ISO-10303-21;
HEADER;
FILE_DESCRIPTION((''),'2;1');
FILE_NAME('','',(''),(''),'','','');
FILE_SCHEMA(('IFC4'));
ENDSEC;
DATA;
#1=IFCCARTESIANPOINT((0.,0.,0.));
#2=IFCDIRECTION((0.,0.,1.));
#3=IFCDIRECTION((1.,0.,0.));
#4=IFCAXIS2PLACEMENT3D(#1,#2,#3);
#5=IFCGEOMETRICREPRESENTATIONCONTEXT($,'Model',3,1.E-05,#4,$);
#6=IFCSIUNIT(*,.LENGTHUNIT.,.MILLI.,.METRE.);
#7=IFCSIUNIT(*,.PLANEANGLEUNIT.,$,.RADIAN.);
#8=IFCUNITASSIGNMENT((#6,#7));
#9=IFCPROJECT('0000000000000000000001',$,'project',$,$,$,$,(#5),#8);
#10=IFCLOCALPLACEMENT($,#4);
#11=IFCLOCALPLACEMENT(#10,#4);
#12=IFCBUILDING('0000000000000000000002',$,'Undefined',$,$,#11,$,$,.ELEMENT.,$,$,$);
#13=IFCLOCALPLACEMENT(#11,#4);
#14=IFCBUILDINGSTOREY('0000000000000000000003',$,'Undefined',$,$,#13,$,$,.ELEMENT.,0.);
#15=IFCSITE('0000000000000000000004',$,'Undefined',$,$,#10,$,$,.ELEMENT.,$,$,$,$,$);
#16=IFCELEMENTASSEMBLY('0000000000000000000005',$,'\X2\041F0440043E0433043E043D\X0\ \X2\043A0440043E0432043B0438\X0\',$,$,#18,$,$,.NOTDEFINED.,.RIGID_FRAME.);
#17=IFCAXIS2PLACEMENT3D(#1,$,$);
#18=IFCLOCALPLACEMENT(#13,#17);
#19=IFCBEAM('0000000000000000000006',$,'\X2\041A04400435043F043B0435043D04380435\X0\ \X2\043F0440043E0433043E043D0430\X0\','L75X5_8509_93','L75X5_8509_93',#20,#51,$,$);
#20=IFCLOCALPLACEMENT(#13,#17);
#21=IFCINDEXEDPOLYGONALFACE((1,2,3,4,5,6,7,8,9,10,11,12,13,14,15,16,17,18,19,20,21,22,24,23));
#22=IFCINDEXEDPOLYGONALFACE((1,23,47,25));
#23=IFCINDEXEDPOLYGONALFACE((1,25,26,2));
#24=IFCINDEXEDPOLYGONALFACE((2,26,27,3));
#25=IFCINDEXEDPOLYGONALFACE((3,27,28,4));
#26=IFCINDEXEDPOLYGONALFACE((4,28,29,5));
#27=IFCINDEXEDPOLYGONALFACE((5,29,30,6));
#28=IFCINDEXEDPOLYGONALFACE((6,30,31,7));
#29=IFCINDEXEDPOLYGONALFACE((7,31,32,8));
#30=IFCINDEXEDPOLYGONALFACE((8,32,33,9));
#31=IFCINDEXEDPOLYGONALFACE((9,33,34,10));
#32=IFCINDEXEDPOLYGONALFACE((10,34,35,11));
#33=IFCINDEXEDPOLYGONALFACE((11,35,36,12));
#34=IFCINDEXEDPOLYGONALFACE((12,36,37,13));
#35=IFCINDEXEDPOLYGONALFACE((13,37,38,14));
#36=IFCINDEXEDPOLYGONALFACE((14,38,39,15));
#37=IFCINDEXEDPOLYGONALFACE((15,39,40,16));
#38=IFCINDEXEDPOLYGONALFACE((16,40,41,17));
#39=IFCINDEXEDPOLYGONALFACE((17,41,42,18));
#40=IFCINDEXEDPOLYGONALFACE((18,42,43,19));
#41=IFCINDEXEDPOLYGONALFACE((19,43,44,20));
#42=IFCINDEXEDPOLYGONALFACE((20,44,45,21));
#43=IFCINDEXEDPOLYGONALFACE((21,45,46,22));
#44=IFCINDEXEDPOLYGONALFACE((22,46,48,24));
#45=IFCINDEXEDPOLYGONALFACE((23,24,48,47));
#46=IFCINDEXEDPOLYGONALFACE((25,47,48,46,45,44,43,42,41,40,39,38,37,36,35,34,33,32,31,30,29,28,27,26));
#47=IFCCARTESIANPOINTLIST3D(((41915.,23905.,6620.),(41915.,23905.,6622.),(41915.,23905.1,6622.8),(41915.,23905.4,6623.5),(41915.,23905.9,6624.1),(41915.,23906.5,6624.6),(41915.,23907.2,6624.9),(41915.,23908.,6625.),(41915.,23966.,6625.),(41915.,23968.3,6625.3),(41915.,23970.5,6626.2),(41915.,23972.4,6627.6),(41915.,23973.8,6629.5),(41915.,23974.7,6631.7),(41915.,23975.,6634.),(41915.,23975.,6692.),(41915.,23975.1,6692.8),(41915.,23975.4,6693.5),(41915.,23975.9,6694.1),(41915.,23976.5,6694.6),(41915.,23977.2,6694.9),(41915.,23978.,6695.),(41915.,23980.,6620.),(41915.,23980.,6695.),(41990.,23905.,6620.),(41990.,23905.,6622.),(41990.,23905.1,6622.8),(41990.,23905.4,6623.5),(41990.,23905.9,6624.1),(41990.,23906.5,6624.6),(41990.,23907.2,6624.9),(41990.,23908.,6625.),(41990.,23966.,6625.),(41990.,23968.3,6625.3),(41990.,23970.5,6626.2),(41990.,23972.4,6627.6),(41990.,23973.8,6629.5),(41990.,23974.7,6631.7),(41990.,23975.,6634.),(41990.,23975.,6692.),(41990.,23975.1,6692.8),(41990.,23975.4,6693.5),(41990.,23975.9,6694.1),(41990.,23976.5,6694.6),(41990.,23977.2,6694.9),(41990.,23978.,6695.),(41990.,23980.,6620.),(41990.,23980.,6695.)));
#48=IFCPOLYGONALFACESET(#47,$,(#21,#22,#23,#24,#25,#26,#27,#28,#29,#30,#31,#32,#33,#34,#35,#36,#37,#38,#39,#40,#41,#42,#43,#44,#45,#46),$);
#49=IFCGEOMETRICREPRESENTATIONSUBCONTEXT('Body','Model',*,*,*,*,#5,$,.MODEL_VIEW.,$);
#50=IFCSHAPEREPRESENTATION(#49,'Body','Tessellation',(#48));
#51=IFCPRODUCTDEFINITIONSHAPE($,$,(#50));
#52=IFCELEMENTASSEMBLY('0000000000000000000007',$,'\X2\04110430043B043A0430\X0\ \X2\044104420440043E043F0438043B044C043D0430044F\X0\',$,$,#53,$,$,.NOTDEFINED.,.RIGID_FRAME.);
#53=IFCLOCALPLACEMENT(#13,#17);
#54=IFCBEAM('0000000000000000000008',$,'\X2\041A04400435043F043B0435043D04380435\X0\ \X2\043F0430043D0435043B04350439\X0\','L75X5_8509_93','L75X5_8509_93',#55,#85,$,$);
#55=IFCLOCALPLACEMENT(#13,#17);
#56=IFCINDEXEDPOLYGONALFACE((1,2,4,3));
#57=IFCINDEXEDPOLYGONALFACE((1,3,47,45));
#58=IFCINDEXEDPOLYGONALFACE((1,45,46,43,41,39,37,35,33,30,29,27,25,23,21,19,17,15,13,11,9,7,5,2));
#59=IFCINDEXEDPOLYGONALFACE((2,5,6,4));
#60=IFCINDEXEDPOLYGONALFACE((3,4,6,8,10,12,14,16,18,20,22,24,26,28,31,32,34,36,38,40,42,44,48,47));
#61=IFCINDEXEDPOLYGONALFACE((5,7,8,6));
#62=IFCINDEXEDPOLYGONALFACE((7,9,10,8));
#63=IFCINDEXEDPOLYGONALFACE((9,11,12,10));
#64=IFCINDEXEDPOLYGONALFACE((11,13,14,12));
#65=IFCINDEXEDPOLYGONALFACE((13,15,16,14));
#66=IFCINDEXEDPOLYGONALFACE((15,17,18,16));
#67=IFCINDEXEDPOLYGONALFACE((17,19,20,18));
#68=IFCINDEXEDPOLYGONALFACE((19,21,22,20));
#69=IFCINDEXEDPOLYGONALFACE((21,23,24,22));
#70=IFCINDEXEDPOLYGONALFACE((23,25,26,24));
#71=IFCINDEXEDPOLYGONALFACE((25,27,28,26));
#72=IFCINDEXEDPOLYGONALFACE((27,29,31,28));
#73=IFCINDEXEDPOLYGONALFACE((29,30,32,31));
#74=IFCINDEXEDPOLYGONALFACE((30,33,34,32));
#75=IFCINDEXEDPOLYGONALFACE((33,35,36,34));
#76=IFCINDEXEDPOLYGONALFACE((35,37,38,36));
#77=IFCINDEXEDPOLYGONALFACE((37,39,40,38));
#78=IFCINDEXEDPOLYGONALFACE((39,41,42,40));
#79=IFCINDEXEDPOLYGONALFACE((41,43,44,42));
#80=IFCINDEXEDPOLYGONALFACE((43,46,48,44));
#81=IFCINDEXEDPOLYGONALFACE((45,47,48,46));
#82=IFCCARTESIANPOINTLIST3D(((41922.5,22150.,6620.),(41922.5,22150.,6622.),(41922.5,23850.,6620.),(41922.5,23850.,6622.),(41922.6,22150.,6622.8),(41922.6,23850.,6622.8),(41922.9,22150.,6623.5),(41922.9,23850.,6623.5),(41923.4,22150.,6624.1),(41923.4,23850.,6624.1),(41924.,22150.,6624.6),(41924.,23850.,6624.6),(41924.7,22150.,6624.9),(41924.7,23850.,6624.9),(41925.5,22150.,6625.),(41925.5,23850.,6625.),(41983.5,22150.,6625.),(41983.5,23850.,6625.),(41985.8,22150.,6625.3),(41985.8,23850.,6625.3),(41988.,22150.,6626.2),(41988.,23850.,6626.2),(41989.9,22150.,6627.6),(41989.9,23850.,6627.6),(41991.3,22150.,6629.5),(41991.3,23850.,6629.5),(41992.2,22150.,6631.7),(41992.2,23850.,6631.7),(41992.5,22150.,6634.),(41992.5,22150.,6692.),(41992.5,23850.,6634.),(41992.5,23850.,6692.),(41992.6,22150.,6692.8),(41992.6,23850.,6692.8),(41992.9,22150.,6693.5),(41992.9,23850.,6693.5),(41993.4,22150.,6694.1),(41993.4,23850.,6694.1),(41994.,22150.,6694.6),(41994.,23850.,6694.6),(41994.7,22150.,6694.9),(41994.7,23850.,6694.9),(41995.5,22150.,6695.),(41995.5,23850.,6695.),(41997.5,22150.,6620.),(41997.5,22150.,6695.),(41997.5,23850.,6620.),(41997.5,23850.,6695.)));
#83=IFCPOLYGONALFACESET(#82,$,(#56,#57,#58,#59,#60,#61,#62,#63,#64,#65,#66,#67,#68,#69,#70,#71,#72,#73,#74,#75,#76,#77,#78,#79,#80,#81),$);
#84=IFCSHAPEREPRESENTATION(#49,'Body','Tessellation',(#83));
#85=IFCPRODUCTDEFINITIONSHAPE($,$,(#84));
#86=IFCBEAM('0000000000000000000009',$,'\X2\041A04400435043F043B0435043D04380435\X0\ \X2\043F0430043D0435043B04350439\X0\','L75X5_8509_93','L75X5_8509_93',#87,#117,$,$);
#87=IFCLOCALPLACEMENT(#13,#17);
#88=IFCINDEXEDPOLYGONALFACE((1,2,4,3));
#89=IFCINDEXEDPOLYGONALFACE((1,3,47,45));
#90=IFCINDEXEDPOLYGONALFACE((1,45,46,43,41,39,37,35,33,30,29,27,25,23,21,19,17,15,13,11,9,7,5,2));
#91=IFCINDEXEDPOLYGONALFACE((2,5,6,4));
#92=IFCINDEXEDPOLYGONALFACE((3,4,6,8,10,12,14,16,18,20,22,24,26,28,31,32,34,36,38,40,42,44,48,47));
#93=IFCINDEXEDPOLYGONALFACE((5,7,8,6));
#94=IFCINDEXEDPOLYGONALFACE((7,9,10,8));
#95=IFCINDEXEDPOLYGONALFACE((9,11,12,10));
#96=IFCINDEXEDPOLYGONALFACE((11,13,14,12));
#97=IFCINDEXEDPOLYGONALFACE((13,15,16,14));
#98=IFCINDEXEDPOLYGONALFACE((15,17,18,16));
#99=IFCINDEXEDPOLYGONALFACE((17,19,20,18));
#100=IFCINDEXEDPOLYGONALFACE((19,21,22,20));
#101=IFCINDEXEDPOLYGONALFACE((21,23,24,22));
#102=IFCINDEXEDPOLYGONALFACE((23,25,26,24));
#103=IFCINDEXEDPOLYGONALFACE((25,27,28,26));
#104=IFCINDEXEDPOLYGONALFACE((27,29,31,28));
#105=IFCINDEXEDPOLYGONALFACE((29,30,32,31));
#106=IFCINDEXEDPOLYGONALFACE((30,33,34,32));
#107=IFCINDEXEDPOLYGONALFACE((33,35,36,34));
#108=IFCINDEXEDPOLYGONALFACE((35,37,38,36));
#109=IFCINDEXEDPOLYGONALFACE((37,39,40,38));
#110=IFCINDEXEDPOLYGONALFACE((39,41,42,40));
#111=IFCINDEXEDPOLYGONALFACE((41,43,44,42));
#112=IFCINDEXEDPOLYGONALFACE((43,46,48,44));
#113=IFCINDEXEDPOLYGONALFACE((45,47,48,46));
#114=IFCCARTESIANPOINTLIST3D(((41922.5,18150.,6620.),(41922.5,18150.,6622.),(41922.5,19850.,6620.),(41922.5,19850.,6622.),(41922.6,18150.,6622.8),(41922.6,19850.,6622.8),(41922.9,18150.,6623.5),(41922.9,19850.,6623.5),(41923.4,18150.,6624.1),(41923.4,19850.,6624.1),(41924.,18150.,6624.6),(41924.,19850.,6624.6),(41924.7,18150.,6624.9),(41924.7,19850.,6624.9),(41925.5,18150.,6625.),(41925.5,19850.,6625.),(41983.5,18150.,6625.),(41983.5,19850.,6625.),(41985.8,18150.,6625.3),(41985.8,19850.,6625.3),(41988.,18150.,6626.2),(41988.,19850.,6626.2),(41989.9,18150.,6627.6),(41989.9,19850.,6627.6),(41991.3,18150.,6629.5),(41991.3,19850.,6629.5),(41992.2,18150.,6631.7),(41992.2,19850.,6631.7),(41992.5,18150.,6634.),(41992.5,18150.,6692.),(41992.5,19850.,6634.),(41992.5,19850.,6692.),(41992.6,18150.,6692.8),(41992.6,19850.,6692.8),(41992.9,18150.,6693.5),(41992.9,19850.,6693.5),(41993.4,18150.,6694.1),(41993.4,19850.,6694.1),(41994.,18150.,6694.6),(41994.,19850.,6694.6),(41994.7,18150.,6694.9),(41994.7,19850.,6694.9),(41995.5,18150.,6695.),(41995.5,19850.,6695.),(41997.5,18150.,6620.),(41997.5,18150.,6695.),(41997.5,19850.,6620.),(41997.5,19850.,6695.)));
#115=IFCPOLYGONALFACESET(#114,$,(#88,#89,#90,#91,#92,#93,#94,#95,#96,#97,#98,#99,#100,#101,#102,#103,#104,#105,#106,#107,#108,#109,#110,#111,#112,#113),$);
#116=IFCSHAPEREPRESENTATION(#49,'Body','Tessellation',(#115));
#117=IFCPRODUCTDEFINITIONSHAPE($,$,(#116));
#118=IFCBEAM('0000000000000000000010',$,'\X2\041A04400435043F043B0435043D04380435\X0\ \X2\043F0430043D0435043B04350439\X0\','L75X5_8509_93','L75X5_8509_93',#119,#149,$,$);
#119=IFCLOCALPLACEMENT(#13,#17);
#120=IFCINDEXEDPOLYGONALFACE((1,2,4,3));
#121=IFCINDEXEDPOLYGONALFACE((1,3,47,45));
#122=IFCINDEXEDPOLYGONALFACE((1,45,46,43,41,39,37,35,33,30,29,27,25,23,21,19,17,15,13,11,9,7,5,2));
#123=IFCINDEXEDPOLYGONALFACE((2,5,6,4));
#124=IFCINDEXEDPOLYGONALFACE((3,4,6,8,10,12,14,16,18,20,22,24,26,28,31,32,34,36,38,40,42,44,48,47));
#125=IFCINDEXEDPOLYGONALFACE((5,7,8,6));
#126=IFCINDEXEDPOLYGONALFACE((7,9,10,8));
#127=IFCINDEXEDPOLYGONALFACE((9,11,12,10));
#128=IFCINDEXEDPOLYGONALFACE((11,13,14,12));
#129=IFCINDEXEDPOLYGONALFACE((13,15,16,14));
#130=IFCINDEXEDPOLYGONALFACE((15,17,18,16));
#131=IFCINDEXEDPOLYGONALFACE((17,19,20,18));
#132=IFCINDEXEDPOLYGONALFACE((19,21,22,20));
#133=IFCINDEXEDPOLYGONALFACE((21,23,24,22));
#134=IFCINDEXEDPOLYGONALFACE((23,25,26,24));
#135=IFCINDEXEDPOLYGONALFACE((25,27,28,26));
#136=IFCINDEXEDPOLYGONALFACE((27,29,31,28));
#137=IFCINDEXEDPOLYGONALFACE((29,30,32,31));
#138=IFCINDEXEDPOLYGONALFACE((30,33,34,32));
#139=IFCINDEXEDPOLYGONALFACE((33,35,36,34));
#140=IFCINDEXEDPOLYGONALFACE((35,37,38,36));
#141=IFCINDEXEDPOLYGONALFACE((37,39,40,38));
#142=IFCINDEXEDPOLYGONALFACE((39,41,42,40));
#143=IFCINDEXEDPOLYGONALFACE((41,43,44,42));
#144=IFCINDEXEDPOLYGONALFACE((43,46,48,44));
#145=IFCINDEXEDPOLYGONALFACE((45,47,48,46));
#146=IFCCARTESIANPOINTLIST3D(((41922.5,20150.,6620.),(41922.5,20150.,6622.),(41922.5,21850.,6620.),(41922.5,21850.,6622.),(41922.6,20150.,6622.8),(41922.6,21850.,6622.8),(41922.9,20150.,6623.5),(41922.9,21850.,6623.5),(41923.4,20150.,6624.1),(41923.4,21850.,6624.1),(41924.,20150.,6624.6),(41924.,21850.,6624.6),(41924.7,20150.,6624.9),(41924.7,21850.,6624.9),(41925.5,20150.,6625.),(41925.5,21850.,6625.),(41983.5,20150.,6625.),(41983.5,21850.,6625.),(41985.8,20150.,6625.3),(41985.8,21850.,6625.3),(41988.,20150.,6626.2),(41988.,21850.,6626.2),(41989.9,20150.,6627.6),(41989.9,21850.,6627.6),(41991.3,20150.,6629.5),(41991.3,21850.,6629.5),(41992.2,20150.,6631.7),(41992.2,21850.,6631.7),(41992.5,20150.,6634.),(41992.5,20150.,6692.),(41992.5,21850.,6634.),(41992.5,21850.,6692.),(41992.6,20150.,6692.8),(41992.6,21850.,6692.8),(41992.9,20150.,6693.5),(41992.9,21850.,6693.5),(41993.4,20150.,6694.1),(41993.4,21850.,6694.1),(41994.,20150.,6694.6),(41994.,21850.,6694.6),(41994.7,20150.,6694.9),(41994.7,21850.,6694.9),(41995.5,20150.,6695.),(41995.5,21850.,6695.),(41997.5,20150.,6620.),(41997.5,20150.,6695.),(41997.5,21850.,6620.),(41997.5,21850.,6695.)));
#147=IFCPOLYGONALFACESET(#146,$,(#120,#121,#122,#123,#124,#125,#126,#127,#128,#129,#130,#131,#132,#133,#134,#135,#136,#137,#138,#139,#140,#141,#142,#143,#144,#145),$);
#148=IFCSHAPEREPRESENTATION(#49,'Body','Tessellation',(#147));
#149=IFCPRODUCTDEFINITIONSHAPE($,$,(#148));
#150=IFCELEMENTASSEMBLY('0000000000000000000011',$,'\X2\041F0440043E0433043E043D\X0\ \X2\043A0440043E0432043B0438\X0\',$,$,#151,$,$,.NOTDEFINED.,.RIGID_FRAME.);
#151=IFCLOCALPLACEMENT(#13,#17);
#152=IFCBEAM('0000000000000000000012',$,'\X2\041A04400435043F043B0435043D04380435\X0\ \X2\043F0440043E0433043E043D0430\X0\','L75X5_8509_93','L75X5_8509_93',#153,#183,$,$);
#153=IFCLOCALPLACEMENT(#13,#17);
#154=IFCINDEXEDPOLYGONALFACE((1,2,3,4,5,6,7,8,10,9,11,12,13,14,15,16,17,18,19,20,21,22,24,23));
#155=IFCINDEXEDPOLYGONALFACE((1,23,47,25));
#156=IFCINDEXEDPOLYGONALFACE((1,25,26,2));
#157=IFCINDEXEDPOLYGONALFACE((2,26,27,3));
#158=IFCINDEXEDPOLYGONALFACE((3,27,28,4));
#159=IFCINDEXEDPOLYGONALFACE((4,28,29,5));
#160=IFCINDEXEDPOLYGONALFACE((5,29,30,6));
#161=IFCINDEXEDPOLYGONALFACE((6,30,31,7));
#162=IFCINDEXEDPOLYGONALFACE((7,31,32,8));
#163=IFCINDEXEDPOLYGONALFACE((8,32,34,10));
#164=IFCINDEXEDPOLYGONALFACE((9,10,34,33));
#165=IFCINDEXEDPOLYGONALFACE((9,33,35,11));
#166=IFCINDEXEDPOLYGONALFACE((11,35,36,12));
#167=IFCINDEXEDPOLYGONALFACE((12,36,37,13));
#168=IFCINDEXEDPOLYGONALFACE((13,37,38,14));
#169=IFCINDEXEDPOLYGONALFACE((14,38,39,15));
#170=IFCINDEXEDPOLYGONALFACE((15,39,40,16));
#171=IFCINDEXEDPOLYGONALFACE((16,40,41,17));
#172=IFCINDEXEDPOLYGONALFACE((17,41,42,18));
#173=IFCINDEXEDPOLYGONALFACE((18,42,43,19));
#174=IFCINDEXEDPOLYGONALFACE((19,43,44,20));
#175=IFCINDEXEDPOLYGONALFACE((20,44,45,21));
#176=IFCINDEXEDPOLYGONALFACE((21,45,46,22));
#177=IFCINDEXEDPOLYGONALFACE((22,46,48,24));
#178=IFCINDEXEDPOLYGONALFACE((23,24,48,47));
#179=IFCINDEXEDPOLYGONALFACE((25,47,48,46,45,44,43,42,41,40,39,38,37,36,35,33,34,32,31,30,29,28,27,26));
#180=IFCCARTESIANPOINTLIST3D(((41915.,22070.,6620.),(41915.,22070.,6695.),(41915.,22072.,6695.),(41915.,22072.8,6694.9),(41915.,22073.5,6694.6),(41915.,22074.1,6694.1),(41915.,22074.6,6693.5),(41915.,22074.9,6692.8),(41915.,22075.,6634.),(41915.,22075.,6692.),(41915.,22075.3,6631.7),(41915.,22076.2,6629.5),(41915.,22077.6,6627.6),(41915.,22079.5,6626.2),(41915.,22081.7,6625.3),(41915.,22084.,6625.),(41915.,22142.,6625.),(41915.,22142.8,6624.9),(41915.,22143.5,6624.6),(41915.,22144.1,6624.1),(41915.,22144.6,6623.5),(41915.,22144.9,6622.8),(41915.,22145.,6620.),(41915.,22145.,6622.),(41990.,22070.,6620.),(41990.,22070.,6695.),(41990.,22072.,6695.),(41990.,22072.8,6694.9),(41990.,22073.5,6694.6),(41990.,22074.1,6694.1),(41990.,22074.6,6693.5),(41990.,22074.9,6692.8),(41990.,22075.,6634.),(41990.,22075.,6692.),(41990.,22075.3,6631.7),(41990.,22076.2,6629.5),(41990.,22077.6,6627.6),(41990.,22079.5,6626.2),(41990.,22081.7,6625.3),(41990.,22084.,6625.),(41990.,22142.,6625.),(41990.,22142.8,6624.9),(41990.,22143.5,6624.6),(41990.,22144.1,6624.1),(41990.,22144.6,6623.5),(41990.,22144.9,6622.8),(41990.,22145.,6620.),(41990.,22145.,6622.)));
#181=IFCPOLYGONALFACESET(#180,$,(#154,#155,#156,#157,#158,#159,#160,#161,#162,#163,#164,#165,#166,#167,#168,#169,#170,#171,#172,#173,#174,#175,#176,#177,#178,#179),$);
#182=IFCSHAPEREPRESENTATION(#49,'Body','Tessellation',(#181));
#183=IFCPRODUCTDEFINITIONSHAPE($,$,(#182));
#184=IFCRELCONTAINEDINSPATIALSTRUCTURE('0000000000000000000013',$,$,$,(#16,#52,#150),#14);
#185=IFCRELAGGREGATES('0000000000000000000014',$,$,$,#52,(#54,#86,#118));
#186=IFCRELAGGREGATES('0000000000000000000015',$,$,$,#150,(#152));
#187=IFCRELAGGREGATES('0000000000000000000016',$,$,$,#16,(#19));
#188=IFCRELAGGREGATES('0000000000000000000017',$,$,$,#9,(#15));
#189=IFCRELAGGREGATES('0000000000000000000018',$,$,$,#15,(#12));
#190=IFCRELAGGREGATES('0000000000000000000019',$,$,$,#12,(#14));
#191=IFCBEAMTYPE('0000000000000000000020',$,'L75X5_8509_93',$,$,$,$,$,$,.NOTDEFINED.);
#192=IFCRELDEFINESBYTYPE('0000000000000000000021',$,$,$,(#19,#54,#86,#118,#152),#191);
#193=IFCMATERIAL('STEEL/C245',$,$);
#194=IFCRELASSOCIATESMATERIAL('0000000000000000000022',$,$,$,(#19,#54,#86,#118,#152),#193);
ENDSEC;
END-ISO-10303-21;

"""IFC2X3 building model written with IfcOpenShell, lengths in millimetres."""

from ifc_helpers import new_model, si_unit, frame, origin_with_axes, origin_2d_with_axis, place, context, subcontext, project, spatial, l_section, extrude, material, type_object, element, aggregate, save


model = new_model("IFC2X3")

# Units and contexts
model_context = context("Model", 3, precision=1e-05, world=origin_with_axes())
body_context = subcontext(model_context, "Body", "Model", "MODEL_VIEW")
ifc_project = project(units=[si_unit("LENGTHUNIT", "METRE", prefix="MILLI"), si_unit("PLANEANGLEUNIT", "RADIAN")], contexts=[model_context])

# Site, building, storey
site_placement = place(None, origin_with_axes())
site = spatial("IfcSite", under=ifc_project, at=site_placement, Name="Undefined", CompositionType="ELEMENT")
building_placement = place(site_placement, origin_with_axes())
building = spatial("IfcBuilding", under=site, at=building_placement, Name="Undefined", CompositionType="ELEMENT")
storey_placement = place(building_placement, origin_with_axes())
storey = spatial("IfcBuildingStorey", under=building, at=storey_placement, Name="Undefined", CompositionType="ELEMENT", Elevation=0.0)

# Element assembly, beam
ifc_material_1 = material(Name="STEEL/C245")
assembly_1_placement = place(storey_placement, origin_with_axes())
assembly_1 = element("IfcElementAssembly", 1, at=assembly_1_placement, inside=storey, Name="Прогон кровли", AssemblyPlace="NOTDEFINED", PredefinedType="RIGID_FRAME")
beam_type_1 = type_object("IfcBeamType", Name="L75X5_8509_93", PredefinedType="NOTDEFINED")
beam_1_placement = place(assembly_1_placement, frame((41990.0, 23942.5, 6657.5), z_axis=(0.0, -1.0, 0.0), x_axis=(-1.0, 0.0, 0.0)))
beam_1 = element("IfcBeam", 2, at=beam_1_placement, type_object=beam_type_1, material=ifc_material_1, Name="Крепление прогона", Description="L75X5_8509_93", ObjectType="L75X5_8509_93", context=body_context, shape_type="SweptSolid", body=[
    extrude(l_section(Depth=75.0, Width=75.0, Thickness=5.0, FilletRadius=9.0, EdgeRadius=3.0, at=origin_2d_with_axis()), frame((75.0, 0.0, 0.0), z_axis=(-1.0, 0.0, 0.0), x_axis=(0.0, -1.0, 0.0)), (0.0, 0.0, 1.0), 75.0),
])

# Element assemblies, beams
assembly_2_placement = place(storey_placement, origin_with_axes())
assembly_2 = element("IfcElementAssembly", 3, at=assembly_2_placement, inside=storey, Name="Балка стропильная", AssemblyPlace="NOTDEFINED", PredefinedType="RIGID_FRAME")
beam_2_placement = place(assembly_2_placement, frame((41960.0, 22150.0, 6657.5), z_axis=(-1.0, 0.0, 0.0), x_axis=(0.0, 1.0, 0.0)))
beam_2 = element("IfcBeam", 4, at=beam_2_placement, type_object=beam_type_1, material=ifc_material_1, Name="Крепление панелей", Description="L75X5_8509_93", ObjectType="L75X5_8509_93", context=body_context, shape_type="SweptSolid", body=[
    extrude(l_section(Depth=75.0, Width=75.0, Thickness=5.0, FilletRadius=9.0, EdgeRadius=3.0, at=origin_2d_with_axis()), frame((1700.0, 0.0, 0.0), z_axis=(-1.0, 0.0, 0.0), x_axis=(0.0, -1.0, 0.0)), (0.0, 0.0, 1.0), 1700.0),
])
beam_3_placement = place(assembly_2_placement, frame((41960.0, 18150.0, 6657.5), z_axis=(-1.0, 0.0, 0.0), x_axis=(0.0, 1.0, 0.0)))
beam_3 = element("IfcBeam", 5, at=beam_3_placement, type_object=beam_type_1, material=ifc_material_1, Name="Крепление панелей", Description="L75X5_8509_93", ObjectType="L75X5_8509_93", context=body_context, shape_type="SweptSolid", body=[
    extrude(l_section(Depth=75.0, Width=75.0, Thickness=5.0, FilletRadius=9.0, EdgeRadius=3.0, at=origin_2d_with_axis()), frame((1700.0, 0.0, 0.0), z_axis=(-1.0, 0.0, 0.0), x_axis=(0.0, -1.0, 0.0)), (0.0, 0.0, 1.0), 1700.0),
])
beam_4_placement = place(assembly_2_placement, frame((41960.0, 20150.0, 6657.5), z_axis=(-1.0, 0.0, 0.0), x_axis=(0.0, 1.0, 0.0)))
beam_4 = element("IfcBeam", 6, at=beam_4_placement, type_object=beam_type_1, material=ifc_material_1, Name="Крепление панелей", Description="L75X5_8509_93", ObjectType="L75X5_8509_93", context=body_context, shape_type="SweptSolid", body=[
    extrude(l_section(Depth=75.0, Width=75.0, Thickness=5.0, FilletRadius=9.0, EdgeRadius=3.0, at=origin_2d_with_axis()), frame((1700.0, 0.0, 0.0), z_axis=(-1.0, 0.0, 0.0), x_axis=(0.0, -1.0, 0.0)), (0.0, 0.0, 1.0), 1700.0),
])
aggregate(assembly_2, [beam_2, beam_3, beam_4])
assembly_3_placement = place(storey_placement, origin_with_axes())
assembly_3 = element("IfcElementAssembly", 7, at=assembly_3_placement, inside=storey, Name="Прогон кровли", AssemblyPlace="NOTDEFINED", PredefinedType="RIGID_FRAME")
beam_5_placement = place(assembly_3_placement, frame((41915.0, 22107.5, 6657.5), z_axis=(0.0, 1.0, 0.0), x_axis=(1.0, 0.0, 0.0)))
beam_5 = element("IfcBeam", 8, at=beam_5_placement, type_object=beam_type_1, material=ifc_material_1, Name="Крепление прогона", Description="L75X5_8509_93", ObjectType="L75X5_8509_93", context=body_context, shape_type="SweptSolid", body=[
    extrude(l_section(Depth=75.0, Width=75.0, Thickness=5.0, FilletRadius=9.0, EdgeRadius=3.0, at=origin_2d_with_axis()), frame((75.0, 0.0, 0.0), z_axis=(-1.0, 0.0, 0.0), x_axis=(0.0, -1.0, 0.0)), (0.0, 0.0, 1.0), 75.0),
])

aggregate(assembly_3, [beam_5])

aggregate(assembly_1, [beam_1])

save(model, "model.ifc")
